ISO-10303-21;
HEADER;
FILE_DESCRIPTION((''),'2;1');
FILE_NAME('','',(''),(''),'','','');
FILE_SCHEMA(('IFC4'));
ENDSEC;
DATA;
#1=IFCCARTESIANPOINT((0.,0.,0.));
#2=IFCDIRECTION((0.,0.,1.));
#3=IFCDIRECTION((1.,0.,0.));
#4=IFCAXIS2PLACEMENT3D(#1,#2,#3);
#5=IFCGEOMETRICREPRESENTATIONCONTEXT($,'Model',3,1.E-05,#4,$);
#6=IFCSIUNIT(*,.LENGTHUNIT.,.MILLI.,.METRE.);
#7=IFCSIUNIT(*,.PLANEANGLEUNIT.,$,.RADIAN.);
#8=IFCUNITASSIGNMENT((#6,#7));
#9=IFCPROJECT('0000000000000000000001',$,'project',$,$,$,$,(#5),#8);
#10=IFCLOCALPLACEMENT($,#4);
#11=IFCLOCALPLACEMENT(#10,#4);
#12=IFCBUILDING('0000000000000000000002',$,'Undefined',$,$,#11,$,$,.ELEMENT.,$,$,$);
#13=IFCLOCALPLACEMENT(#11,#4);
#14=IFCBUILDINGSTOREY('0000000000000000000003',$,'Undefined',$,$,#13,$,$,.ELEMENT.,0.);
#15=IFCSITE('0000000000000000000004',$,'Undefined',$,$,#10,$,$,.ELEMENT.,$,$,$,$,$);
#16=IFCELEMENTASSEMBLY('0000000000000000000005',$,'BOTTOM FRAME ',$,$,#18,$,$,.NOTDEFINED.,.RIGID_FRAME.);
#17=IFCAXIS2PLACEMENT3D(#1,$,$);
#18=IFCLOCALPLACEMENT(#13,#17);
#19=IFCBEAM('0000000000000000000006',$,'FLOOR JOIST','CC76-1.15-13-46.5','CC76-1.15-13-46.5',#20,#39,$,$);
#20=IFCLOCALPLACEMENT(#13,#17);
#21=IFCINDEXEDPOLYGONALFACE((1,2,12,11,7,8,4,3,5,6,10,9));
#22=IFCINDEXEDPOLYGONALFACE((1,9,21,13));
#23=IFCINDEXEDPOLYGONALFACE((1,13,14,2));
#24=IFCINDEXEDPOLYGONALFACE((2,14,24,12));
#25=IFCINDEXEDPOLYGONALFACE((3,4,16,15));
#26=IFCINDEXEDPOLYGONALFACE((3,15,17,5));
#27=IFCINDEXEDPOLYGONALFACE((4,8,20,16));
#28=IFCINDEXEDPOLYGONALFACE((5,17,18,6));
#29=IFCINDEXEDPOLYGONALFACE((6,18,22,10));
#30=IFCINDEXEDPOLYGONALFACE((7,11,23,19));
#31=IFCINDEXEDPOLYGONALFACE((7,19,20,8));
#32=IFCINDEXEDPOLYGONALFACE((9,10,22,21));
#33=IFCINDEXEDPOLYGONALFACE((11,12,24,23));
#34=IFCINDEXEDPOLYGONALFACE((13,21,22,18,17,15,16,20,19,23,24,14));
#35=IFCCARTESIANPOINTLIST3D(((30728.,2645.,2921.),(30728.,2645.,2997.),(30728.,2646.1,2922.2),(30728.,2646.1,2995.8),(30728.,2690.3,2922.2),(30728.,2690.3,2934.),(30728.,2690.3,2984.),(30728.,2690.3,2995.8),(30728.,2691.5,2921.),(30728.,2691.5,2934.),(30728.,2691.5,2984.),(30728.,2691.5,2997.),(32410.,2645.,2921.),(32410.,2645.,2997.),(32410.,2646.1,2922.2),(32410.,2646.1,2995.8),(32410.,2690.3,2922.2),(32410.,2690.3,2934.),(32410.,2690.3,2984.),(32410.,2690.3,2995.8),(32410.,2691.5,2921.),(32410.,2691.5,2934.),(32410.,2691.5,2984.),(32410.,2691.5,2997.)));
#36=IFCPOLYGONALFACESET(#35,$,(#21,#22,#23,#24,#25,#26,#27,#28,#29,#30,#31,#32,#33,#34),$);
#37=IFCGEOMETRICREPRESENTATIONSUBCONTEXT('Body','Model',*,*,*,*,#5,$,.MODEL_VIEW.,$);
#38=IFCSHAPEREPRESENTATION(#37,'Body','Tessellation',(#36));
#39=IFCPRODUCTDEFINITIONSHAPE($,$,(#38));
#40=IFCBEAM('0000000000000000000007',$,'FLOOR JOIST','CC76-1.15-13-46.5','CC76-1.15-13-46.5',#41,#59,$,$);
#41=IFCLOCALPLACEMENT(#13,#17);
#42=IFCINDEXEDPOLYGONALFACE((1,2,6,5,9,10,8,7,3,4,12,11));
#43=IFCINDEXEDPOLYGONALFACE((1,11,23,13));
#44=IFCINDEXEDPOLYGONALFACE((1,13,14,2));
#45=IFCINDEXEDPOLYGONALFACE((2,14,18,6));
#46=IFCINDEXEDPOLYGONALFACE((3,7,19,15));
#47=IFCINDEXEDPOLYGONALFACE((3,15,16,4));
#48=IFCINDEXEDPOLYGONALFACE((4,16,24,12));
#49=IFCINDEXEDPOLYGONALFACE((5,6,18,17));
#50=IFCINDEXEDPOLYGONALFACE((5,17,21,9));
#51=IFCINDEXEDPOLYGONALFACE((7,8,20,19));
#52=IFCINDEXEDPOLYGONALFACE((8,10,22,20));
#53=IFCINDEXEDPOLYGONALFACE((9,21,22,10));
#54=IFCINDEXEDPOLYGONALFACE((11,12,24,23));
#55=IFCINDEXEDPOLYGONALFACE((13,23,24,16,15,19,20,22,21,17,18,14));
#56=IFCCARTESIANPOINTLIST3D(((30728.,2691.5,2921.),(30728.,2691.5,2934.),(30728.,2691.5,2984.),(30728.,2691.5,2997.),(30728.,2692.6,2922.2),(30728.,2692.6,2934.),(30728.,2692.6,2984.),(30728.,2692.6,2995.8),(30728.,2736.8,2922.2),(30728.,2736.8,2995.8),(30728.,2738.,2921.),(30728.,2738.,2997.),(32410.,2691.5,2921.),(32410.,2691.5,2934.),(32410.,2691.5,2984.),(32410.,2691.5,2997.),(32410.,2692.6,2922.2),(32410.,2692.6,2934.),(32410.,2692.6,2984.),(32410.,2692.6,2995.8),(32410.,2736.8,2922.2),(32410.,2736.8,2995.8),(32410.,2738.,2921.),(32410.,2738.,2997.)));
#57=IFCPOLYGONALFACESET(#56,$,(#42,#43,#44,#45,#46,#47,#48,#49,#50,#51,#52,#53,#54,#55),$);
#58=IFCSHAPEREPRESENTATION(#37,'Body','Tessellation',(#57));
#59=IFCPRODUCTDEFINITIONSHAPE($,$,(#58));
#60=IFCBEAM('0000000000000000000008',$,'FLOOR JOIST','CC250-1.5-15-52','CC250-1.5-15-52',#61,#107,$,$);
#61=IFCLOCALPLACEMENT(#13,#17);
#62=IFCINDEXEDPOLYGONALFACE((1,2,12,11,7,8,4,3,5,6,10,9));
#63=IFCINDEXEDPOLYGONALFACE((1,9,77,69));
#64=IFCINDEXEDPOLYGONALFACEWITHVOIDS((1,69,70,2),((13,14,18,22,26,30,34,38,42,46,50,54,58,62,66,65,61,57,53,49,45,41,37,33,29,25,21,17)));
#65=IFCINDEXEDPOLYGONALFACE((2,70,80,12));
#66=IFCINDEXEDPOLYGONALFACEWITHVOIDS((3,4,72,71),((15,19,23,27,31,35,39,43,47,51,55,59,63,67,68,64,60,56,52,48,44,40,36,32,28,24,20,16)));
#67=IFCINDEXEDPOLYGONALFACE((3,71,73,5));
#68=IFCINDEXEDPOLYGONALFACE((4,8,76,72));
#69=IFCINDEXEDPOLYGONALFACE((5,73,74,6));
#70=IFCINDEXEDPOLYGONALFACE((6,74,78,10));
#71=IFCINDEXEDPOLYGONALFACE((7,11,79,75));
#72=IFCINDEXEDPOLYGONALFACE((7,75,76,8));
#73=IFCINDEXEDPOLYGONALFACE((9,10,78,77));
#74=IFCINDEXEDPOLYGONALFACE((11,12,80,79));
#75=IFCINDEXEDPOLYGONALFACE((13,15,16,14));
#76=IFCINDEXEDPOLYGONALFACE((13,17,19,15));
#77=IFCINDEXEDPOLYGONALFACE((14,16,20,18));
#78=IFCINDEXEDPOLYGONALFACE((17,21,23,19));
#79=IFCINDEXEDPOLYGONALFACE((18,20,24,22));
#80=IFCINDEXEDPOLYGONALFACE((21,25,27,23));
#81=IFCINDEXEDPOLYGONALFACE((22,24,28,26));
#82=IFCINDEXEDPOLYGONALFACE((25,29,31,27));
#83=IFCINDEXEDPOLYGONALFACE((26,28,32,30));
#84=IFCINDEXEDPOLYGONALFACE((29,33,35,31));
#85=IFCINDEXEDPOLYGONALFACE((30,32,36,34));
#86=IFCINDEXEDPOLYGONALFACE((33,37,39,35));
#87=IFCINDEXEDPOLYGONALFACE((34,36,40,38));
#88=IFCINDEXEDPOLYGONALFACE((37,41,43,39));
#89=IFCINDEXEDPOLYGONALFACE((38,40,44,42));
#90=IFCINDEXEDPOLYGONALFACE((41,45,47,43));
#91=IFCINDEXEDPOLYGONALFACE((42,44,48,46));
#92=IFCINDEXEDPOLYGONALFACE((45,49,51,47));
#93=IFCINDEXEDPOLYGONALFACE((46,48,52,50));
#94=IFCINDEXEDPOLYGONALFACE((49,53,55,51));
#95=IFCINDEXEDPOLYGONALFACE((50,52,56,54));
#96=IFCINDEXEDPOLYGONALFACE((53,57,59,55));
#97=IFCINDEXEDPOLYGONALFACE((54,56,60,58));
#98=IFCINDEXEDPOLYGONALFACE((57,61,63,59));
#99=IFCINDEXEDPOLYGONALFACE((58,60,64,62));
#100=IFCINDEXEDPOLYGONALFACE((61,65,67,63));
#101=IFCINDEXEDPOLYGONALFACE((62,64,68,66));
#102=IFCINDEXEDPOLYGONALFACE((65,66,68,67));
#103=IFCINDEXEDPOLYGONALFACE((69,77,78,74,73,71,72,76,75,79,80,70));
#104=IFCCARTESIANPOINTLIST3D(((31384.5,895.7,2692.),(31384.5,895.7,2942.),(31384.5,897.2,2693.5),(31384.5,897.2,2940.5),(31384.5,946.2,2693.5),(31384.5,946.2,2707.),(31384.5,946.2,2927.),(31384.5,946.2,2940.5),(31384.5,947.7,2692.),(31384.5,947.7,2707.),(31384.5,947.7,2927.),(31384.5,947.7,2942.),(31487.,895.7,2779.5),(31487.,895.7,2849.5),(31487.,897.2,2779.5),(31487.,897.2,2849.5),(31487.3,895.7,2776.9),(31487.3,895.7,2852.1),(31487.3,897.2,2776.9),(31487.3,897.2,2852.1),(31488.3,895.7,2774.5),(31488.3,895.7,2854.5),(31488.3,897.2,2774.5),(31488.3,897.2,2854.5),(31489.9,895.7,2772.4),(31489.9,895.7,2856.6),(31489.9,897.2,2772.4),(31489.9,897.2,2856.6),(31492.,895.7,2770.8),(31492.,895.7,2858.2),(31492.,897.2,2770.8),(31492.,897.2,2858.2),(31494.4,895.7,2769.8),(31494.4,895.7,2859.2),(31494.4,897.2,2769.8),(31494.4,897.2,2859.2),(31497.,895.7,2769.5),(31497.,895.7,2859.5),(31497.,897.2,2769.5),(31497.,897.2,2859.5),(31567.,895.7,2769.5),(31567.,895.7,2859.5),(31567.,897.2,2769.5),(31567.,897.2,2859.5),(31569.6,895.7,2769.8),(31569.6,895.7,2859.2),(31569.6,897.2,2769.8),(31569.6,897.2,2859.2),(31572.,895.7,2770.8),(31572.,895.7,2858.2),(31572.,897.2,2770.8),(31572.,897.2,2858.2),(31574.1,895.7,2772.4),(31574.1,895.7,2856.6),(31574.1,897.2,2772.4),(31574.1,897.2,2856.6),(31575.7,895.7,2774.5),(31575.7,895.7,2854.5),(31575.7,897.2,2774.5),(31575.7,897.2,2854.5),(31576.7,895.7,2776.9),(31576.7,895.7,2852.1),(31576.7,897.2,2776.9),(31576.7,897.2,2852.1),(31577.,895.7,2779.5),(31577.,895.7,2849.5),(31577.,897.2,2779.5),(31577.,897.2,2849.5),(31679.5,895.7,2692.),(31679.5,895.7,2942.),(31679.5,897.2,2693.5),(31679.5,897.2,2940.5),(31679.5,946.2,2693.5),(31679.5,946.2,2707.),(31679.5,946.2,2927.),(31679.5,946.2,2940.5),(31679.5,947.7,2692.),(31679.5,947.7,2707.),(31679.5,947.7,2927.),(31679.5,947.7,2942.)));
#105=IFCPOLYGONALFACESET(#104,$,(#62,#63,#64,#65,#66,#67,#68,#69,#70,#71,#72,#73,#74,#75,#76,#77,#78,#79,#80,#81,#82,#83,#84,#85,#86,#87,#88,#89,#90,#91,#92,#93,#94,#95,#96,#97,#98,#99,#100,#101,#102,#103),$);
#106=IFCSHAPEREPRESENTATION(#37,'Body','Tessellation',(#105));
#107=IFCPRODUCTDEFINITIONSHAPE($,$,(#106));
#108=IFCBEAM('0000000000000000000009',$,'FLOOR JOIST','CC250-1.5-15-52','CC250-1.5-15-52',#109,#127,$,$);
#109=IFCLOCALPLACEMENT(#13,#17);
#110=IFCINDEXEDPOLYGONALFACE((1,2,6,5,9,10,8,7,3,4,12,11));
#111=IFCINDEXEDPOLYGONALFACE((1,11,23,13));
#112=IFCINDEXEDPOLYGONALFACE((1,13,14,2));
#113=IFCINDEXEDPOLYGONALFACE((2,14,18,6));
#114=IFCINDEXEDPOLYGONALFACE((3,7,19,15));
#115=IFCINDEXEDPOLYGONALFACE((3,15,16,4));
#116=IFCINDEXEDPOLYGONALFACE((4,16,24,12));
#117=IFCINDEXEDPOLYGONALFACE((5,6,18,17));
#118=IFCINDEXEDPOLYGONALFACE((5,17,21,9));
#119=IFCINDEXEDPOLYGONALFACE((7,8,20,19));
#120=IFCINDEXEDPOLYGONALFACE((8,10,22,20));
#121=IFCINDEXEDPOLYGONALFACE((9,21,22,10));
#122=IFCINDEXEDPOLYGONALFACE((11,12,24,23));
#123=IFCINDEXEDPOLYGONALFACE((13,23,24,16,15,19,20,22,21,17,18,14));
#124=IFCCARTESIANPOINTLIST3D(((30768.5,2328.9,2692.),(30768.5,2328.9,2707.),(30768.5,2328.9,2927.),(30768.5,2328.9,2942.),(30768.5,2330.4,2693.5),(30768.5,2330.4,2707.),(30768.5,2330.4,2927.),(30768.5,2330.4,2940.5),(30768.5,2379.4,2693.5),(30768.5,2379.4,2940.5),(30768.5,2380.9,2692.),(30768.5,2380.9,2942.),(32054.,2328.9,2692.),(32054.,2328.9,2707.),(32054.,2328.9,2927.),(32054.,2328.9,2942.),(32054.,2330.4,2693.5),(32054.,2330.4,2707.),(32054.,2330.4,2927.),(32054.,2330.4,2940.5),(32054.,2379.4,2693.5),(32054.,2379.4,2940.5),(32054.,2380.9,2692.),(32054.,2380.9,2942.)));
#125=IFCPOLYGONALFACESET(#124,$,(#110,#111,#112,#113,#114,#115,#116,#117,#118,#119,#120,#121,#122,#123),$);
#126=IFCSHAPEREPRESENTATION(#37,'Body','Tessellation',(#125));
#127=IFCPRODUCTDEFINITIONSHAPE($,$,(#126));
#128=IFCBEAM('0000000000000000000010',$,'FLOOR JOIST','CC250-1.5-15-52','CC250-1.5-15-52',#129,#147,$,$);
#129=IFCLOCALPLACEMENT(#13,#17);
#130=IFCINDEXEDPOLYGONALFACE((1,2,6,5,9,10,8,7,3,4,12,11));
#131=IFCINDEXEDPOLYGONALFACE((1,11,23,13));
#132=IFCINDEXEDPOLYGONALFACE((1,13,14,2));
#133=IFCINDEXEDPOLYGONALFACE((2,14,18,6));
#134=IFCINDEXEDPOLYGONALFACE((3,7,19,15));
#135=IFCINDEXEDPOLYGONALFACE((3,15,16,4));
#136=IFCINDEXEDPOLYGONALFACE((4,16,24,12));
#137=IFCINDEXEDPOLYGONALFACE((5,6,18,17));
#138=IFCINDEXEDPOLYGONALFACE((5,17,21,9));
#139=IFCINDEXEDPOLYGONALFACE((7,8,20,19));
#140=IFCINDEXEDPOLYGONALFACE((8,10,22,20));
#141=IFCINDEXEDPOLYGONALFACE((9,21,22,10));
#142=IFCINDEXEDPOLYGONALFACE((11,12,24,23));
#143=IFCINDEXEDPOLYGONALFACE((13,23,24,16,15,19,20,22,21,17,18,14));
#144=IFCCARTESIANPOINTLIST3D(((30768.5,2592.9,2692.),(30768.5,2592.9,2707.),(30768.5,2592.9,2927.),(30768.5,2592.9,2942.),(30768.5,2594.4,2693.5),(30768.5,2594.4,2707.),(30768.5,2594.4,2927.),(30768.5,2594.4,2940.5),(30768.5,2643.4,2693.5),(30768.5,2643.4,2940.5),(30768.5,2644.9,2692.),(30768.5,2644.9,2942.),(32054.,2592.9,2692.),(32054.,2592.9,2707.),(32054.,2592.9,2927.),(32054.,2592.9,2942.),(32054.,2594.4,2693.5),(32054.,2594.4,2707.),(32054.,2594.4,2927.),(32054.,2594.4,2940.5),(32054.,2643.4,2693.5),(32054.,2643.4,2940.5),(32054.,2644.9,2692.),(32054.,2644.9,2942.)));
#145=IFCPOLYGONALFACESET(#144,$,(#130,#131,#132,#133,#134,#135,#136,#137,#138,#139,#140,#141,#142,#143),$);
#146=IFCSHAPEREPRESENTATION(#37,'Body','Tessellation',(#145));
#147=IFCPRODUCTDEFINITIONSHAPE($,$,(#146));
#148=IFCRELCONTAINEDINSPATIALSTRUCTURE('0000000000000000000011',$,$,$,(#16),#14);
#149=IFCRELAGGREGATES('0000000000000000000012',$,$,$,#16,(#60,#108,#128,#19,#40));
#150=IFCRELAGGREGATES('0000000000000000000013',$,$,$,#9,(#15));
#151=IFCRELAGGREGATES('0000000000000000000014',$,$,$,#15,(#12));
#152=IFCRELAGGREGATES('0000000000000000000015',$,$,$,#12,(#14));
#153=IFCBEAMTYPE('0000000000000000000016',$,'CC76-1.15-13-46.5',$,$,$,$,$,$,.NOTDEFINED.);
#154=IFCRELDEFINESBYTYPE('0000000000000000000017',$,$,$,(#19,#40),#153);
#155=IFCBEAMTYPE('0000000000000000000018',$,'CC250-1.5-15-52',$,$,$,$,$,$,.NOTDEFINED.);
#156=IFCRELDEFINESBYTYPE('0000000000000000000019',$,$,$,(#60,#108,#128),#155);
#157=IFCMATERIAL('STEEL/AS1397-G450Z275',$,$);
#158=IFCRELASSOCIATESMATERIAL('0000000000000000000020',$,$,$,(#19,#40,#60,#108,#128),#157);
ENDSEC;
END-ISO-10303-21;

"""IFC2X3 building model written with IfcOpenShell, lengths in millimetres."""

from ifc_helpers import new_model, si_unit, frame, frame_2d, origin_with_axes, origin_2d_with_axis, place, context, subcontext, project, spatial, polyline, circle_curve, parameter, trimmed, segment, composite_curve, c_section, outline, extrude, boolean, material, type_object, element, aggregate, save


model = new_model("IFC2X3")

# Units and contexts
model_context = context("Model", 3, precision=1e-05, world=origin_with_axes())
body_context = subcontext(model_context, "Body", "Model", "MODEL_VIEW")
ifc_project = project(units=[si_unit("LENGTHUNIT", "METRE", prefix="MILLI"), si_unit("PLANEANGLEUNIT", "RADIAN")], contexts=[model_context])

# Site, building, storey
site_placement = place(None, origin_with_axes())
site = spatial("IfcSite", under=ifc_project, at=site_placement, Name="Undefined", CompositionType="ELEMENT")
building_placement = place(site_placement, origin_with_axes())
building = spatial("IfcBuilding", under=site, at=building_placement, Name="Undefined", CompositionType="ELEMENT")
storey_placement = place(building_placement, origin_with_axes())
storey = spatial("IfcBuildingStorey", under=building, at=storey_placement, Name="Undefined", CompositionType="ELEMENT", Elevation=0.0)

# Element assembly, beams
assembly_1_placement = place(storey_placement, origin_with_axes())
assembly_1 = element("IfcElementAssembly", 1, at=assembly_1_placement, inside=storey, Name="BOTTOM FRAME ", AssemblyPlace="NOTDEFINED", PredefinedType="RIGID_FRAME")
ifc_material_1 = material(Name="STEEL/AS1397-G450Z275")
beam_type_1 = type_object("IfcBeamType", Name="CC76-1.15-13-46.5", PredefinedType="NOTDEFINED")
beam_1_placement = place(assembly_1_placement, frame((30728.0, 2668.2, 2959.0), z_axis=(0.0, 0.0, -1.0), x_axis=(1.0, 0.0, 0.0)))
beam_1 = element("IfcBeam", 2, at=beam_1_placement, type_object=beam_type_1, material=ifc_material_1, Name="FLOOR JOIST", Description="CC76-1.15-13-46.5", ObjectType="CC76-1.15-13-46.5", context=body_context, shape_type="SweptSolid", body=[
    extrude(c_section(Depth=76.0, Width=46.5, WallThickness=1.1, Girth=13.0, at=origin_2d_with_axis()), frame((1682.0, 0.0, 0.0), z_axis=(-1.0, 0.0, 0.0), x_axis=(0.0, -1.0, 0.0)), (0.0, 0.0, 1.0), 1682.0),
])
beam_2_placement = place(assembly_1_placement, frame((30728.0, 2714.7, 2959.0), z_axis=(0.0, 0.0, 1.0), x_axis=(1.0, 0.0, 0.0)))
beam_2 = element("IfcBeam", 3, at=beam_2_placement, type_object=beam_type_1, material=ifc_material_1, Name="FLOOR JOIST", Description="CC76-1.15-13-46.5", ObjectType="CC76-1.15-13-46.5", context=body_context, shape_type="SweptSolid", body=[
    extrude(c_section(Depth=76.0, Width=46.5, WallThickness=1.1, Girth=13.0, at=origin_2d_with_axis()), frame((1682.0, 0.0, 0.0), z_axis=(-1.0, 0.0, 0.0), x_axis=(0.0, -1.0, 0.0)), (0.0, 0.0, 1.0), 1682.0),
])
beam_type_2 = type_object("IfcBeamType", Name="CC250-1.5-15-52", PredefinedType="NOTDEFINED")
beam_3_placement = place(assembly_1_placement, frame((31384.5, 921.7, 2817.0), z_axis=(0.0, 0.0, -1.0), x_axis=(1.0, 0.0, 0.0)))
beam_3 = element("IfcBeam", 4, at=beam_3_placement, type_object=beam_type_2, material=ifc_material_1, Name="FLOOR JOIST", Description="CC250-1.5-15-52", ObjectType="CC250-1.5-15-52", context=body_context, shape_type="CSG", body=[
    boolean("DIFFERENCE", extrude(c_section(Depth=250.0, Width=52.0, WallThickness=1.5, Girth=15.0, at=origin_2d_with_axis()), frame((295.0, 0.0, 0.0), z_axis=(-1.0, 0.0, 0.0), x_axis=(0.0, -1.0, 0.0)), (0.0, 0.0, 1.0), 295.0), extrude(outline(composite_curve([segment(trimmed(circle_curve(frame_2d((10.0, 10.0), x_axis=(-1.0, 0.0)), 10.0), [parameter(0.0)], [parameter(1.570796)], True, "PARAMETER"), True, "CONTINUOUS"), segment(polyline([(10.0, 0.0), (80.0, 0.0)]), True, "CONTINUOUS"), segment(trimmed(circle_curve(frame_2d((80.0, 10.0), x_axis=(0.0, -1.0)), 10.0), [parameter(0.0)], [parameter(1.570796)], True, "PARAMETER"), True, "CONTINUOUS"), segment(polyline([(90.0, 10.0), (90.0, 80.0)]), True, "CONTINUOUS"), segment(trimmed(circle_curve(frame_2d((80.0, 80.0), x_axis=(1.0, 0.0)), 10.0), [parameter(0.0)], [parameter(1.570796)], True, "PARAMETER"), True, "CONTINUOUS"), segment(polyline([(80.0, 90.0), (10.0, 90.0)]), True, "CONTINUOUS"), segment(trimmed(circle_curve(frame_2d((10.0, 80.0), x_axis=(0.0, 1.0)), 10.0), [parameter(0.0)], [parameter(1.570796)], True, "PARAMETER"), True, "CONTINUOUS"), segment(polyline([(0.0, 80.0), (0.0, 10.0)]), True, "CONTINUOUS")], self_intersect=True)), frame((102.5, 40.5, -42.5), z_axis=(0.0, -1.0, 0.0), x_axis=(1.0, 0.0, 0.0)), (0.0, 0.0, 1.0), 81.0)),
])
beam_4_placement = place(assembly_1_placement, frame((30768.5, 2354.9, 2817.0), z_axis=(0.0, 0.0, 1.0), x_axis=(1.0, 0.0, 0.0)))
beam_4 = element("IfcBeam", 5, at=beam_4_placement, type_object=beam_type_2, material=ifc_material_1, Name="FLOOR JOIST", Description="CC250-1.5-15-52", ObjectType="CC250-1.5-15-52", context=body_context, shape_type="SweptSolid", body=[
    extrude(c_section(Depth=250.0, Width=52.0, WallThickness=1.5, Girth=15.0, at=origin_2d_with_axis()), frame((1285.5, 0.0, 0.0), z_axis=(-1.0, 0.0, 0.0), x_axis=(0.0, -1.0, 0.0)), (0.0, 0.0, 1.0), 1285.5),
])
beam_5_placement = place(assembly_1_placement, frame((30768.5, 2618.9, 2817.0), z_axis=(0.0, 0.0, 1.0), x_axis=(1.0, 0.0, 0.0)))
beam_5 = element("IfcBeam", 6, at=beam_5_placement, type_object=beam_type_2, material=ifc_material_1, Name="FLOOR JOIST", Description="CC250-1.5-15-52", ObjectType="CC250-1.5-15-52", context=body_context, shape_type="SweptSolid", body=[
    extrude(c_section(Depth=250.0, Width=52.0, WallThickness=1.5, Girth=15.0, at=origin_2d_with_axis()), frame((1285.5, 0.0, 0.0), z_axis=(-1.0, 0.0, 0.0), x_axis=(0.0, -1.0, 0.0)), (0.0, 0.0, 1.0), 1285.5),
])
aggregate(assembly_1, [beam_3, beam_4, beam_5, beam_1, beam_2])

save(model, "model.ifc")
